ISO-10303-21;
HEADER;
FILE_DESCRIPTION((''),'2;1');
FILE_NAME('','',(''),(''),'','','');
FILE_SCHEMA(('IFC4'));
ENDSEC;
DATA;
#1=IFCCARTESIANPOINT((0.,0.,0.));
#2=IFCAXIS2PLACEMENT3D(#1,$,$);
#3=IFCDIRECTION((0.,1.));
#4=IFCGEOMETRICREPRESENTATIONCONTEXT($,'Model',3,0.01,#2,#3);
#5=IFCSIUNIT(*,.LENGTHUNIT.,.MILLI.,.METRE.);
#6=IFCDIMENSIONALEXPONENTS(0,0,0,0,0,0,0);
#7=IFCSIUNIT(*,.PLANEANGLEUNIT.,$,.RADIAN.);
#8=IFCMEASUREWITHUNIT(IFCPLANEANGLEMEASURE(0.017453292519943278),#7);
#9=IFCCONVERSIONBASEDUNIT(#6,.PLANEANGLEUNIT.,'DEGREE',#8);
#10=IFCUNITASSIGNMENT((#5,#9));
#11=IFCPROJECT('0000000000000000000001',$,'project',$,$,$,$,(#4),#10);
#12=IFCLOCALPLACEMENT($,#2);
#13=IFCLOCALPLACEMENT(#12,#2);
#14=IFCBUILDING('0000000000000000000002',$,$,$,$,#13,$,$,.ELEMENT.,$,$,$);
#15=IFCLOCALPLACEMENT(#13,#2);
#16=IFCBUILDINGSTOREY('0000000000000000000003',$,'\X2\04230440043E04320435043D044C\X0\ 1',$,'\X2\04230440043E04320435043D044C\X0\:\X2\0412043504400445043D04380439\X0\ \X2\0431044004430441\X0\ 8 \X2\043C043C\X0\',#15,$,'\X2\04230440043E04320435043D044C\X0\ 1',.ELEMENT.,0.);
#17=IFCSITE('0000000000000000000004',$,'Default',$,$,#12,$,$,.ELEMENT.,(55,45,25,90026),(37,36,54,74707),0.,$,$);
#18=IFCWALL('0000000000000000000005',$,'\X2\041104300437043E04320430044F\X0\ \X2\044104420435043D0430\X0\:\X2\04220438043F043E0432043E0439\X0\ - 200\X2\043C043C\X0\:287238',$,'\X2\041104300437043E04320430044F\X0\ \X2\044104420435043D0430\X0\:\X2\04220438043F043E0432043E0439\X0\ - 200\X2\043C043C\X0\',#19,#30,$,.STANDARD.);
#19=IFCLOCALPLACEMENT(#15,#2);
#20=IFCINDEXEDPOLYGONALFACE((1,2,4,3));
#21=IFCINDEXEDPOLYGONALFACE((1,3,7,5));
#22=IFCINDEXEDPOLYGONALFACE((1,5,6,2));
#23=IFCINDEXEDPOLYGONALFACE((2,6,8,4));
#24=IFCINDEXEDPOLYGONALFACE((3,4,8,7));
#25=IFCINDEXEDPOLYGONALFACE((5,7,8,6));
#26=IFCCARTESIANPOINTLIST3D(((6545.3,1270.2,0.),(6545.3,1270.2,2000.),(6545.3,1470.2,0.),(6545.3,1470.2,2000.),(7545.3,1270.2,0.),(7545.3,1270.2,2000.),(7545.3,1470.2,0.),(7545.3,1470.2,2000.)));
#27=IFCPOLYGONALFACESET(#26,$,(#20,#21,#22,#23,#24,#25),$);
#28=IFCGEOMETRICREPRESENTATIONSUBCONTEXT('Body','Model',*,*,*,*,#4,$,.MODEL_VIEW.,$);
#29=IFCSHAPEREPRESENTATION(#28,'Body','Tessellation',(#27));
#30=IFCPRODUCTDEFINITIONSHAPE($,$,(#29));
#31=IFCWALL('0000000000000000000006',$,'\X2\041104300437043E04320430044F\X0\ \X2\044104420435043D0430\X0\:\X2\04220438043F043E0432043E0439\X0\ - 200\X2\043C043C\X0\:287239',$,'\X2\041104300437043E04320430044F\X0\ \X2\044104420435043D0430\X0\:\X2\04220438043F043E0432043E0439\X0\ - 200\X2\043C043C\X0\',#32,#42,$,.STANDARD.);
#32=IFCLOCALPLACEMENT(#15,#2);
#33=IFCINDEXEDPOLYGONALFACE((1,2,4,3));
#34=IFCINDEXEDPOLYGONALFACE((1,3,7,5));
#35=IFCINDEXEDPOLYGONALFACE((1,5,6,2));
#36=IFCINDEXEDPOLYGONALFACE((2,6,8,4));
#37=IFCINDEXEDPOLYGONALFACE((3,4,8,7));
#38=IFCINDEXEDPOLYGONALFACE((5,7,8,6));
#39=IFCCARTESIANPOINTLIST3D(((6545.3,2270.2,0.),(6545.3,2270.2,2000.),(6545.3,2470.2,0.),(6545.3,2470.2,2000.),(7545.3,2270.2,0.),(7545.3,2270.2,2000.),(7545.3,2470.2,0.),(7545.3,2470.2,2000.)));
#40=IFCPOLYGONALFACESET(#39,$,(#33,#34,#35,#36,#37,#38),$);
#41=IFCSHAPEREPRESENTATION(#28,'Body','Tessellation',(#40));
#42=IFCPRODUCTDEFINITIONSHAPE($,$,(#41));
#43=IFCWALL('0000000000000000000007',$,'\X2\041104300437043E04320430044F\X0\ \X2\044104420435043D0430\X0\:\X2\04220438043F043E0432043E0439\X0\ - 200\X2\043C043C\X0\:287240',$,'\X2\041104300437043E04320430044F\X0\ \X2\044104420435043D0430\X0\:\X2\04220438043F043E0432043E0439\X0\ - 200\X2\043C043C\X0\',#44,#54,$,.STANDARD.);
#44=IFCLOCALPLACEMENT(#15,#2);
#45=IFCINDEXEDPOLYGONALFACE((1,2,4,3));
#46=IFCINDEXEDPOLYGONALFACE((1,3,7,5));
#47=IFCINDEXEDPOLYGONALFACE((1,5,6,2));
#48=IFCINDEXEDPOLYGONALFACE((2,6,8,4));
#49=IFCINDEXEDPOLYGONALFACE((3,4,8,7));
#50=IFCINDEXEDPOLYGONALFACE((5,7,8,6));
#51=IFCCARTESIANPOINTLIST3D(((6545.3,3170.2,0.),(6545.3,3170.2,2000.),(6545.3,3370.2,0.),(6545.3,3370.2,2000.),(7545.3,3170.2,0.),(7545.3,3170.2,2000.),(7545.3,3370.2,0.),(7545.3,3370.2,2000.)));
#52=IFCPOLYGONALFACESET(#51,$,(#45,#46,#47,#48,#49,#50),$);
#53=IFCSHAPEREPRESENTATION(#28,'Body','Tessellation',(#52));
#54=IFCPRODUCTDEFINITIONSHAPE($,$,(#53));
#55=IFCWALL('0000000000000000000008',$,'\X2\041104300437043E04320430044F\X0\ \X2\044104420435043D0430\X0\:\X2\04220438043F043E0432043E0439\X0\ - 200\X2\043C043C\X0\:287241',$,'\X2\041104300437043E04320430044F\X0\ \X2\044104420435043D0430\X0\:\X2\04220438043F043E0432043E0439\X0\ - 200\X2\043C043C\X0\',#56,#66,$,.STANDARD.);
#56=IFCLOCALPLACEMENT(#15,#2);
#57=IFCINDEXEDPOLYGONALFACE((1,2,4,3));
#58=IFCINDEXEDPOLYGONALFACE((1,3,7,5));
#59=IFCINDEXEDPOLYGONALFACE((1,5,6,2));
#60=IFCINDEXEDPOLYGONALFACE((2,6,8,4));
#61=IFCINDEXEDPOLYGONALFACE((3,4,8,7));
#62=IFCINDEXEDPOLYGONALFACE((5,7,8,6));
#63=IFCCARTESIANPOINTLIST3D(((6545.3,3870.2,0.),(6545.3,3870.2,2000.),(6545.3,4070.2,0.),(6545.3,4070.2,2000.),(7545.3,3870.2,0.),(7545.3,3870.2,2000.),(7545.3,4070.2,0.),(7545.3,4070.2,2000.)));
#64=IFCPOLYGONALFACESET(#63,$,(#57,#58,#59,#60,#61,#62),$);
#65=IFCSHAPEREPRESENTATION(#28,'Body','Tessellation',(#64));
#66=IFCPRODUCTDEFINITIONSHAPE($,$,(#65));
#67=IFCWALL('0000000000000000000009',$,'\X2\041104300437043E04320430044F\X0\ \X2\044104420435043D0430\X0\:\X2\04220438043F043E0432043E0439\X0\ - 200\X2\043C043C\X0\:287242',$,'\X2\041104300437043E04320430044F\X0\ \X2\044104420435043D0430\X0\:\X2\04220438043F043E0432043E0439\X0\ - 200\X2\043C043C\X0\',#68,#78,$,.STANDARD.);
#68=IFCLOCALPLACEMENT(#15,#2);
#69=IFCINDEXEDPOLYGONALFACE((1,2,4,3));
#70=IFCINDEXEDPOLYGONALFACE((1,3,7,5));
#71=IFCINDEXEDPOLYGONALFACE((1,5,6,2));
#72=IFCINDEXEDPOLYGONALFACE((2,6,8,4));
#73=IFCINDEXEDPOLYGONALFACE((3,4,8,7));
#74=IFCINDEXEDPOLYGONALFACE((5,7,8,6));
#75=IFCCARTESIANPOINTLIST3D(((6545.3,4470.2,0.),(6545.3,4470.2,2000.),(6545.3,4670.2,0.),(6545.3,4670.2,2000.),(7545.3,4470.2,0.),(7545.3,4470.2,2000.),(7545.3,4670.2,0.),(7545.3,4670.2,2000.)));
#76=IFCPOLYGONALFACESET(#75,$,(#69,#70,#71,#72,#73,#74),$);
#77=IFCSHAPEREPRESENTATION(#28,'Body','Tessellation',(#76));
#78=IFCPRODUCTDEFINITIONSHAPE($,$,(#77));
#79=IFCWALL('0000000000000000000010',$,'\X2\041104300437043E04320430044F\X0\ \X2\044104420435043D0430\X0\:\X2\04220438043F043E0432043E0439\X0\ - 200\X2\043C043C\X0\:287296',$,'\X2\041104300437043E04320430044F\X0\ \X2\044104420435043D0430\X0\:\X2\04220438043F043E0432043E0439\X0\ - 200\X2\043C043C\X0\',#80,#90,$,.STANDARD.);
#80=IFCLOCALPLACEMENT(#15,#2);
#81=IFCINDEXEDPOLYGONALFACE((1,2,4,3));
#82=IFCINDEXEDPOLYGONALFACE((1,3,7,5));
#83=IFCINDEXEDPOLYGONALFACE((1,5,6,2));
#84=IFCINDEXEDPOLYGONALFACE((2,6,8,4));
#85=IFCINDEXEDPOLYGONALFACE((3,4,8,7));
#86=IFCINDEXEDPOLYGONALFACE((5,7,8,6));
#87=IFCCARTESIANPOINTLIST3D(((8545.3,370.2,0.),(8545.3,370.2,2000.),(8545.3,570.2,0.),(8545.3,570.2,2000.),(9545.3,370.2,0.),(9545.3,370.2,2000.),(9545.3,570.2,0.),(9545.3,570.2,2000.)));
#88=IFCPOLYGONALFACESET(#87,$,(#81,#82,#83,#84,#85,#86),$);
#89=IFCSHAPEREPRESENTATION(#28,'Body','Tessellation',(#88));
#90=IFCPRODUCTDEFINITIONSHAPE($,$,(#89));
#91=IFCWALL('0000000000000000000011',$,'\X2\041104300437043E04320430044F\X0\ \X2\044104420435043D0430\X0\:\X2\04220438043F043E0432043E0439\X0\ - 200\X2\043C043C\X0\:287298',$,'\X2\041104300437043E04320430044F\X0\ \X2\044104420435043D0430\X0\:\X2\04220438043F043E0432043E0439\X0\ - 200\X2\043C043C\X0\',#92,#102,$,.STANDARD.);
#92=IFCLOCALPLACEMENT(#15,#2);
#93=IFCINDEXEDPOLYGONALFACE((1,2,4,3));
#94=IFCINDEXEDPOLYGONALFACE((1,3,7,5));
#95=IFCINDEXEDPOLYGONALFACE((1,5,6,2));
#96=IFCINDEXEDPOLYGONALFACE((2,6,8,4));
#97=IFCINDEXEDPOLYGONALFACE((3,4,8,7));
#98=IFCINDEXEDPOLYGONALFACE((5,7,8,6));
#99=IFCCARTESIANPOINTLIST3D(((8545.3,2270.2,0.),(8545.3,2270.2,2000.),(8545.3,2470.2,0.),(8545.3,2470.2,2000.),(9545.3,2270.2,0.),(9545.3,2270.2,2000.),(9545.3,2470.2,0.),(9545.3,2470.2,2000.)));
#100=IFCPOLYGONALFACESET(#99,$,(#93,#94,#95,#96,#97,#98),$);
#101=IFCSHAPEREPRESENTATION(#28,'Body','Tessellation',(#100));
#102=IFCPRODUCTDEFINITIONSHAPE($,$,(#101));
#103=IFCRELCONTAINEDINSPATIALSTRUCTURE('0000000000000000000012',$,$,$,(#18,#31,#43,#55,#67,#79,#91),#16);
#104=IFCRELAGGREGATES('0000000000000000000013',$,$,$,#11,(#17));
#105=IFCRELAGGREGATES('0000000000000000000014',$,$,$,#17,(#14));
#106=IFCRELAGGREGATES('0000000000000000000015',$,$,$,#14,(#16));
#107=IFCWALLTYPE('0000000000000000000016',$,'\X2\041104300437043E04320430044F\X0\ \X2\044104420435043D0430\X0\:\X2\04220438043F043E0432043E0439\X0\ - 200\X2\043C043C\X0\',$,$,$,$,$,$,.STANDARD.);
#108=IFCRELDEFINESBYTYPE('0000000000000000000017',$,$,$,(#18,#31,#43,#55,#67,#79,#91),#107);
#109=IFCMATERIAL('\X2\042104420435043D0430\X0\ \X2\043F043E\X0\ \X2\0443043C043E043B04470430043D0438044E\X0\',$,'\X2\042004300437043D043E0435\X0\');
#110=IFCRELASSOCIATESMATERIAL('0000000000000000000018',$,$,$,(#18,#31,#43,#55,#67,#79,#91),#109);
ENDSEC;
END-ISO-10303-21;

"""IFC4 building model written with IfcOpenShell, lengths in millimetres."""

from ifc_helpers import new_model, entity, si_unit, converted_unit, direction, frame, origin, place, context, subcontext, project, spatial, indexed_curve, outline, extrude, material, type_object, element, save


model = new_model("IFC4")

# Units and contexts
model_context = context("Model", 3, precision=0.01, world=origin(), true_north=direction((0.0, 1.0)))
body_context = subcontext(model_context, "Body", "Model", "MODEL_VIEW")
ifc_project = project(units=[si_unit("LENGTHUNIT", "METRE", prefix="MILLI"), converted_unit("PLANEANGLEUNIT", "DEGREE", entity("IfcPlaneAngleMeasure", 0.017453292519943278), si_unit("PLANEANGLEUNIT", "RADIAN"), dimensions=[0, 0, 0, 0, 0, 0, 0])], contexts=[model_context])

# Site, building, storey
site_placement = place(None, origin())
site = spatial("IfcSite", under=ifc_project, at=site_placement, Name="Default", CompositionType="ELEMENT", RefLatitude=(55, 45, 25, 90026), RefLongitude=(37, 36, 54, 74707), RefElevation=0.0)
building_placement = place(site_placement, origin())
building = spatial("IfcBuilding", under=site, at=building_placement, CompositionType="ELEMENT")
storey_placement = place(building_placement, origin())
storey = spatial("IfcBuildingStorey", under=building, at=storey_placement, Name="Уровень 1", ObjectType="Уровень:Верхний брус 8 мм", LongName="Уровень 1", CompositionType="ELEMENT", Elevation=0.0)

# Walls
ifc_material = material(Name="Стена по умолчанию", Category="Разное")
wall_type = type_object("IfcWallType", Name="Базовая стена:Типовой - 200мм", PredefinedType="STANDARD")
for number, where, name in (
    (1, (6545.3, 1370.2, 0.0), "Базовая стена:Типовой - 200мм:287238"),
):
    element("IfcWall", number, at=place(storey_placement, frame(where)), inside=storey, type_object=wall_type, material=ifc_material, Name=name, ObjectType="Базовая стена:Типовой - 200мм", PredefinedType="STANDARD", context=body_context, shape_type="SweptSolid", body=[
        extrude(outline(indexed_curve([(1000.0, 100.0), (0.0, 100.0), (0.0, -100.0), (1000.0, -100.0), (1000.0, 100.0)], self_intersect=False)), origin(), (0.0, 0.0, 1.0), 2000.0),
    ])
for number, where, name in (
    (2, (6545.3, 2370.2, 0.0), "Базовая стена:Типовой - 200мм:287239"),
    (3, (6545.3, 3270.2, 0.0), "Базовая стена:Типовой - 200мм:287240"),
    (4, (6545.3, 3970.2, 0.0), "Базовая стена:Типовой - 200мм:287241"),
):
    element("IfcWall", number, at=place(storey_placement, frame(where)), inside=storey, type_object=wall_type, material=ifc_material, Name=name, ObjectType="Базовая стена:Типовой - 200мм", PredefinedType="STANDARD", context=body_context, shape_type="SweptSolid", body=[
        extrude(outline(indexed_curve([(1000.0, 100.0), (0.0, 100.0), (0.0, -100.0), (1000.0, -100.0), (1000.0, 100.0)], self_intersect=False)), origin(), (0.0, 0.0, 1.0), 2000.0),
    ])
for number, where, name in (
    (5, (6545.3, 4570.2, 0.0), "Базовая стена:Типовой - 200мм:287242"),
    (6, (8545.3, 470.2, 0.0), "Базовая стена:Типовой - 200мм:287296"),
):
    element("IfcWall", number, at=place(storey_placement, frame(where)), inside=storey, type_object=wall_type, material=ifc_material, Name=name, ObjectType="Базовая стена:Типовой - 200мм", PredefinedType="STANDARD", context=body_context, shape_type="SweptSolid", body=[
        extrude(outline(indexed_curve([(1000.0, 100.0), (0.0, 100.0), (0.0, -100.0), (1000.0, -100.0), (1000.0, 100.0)], self_intersect=False)), origin(), (0.0, 0.0, 1.0), 2000.0),
    ])
wall_1_placement = place(storey_placement, frame((8545.3, 2370.2, 0.0)))
element("IfcWall", 7, at=wall_1_placement, inside=storey, type_object=wall_type, material=ifc_material, Name="Базовая стена:Типовой - 200мм:287298", ObjectType="Базовая стена:Типовой - 200мм", PredefinedType="STANDARD", context=body_context, shape_type="SweptSolid", body=[
    extrude(outline(indexed_curve([(1000.0, 100.0), (0.0, 100.0), (0.0, -100.0), (1000.0, -100.0), (1000.0, 100.0)], self_intersect=False)), origin(), (0.0, 0.0, 1.0), 2000.0),
])

save(model, "model.ifc")
